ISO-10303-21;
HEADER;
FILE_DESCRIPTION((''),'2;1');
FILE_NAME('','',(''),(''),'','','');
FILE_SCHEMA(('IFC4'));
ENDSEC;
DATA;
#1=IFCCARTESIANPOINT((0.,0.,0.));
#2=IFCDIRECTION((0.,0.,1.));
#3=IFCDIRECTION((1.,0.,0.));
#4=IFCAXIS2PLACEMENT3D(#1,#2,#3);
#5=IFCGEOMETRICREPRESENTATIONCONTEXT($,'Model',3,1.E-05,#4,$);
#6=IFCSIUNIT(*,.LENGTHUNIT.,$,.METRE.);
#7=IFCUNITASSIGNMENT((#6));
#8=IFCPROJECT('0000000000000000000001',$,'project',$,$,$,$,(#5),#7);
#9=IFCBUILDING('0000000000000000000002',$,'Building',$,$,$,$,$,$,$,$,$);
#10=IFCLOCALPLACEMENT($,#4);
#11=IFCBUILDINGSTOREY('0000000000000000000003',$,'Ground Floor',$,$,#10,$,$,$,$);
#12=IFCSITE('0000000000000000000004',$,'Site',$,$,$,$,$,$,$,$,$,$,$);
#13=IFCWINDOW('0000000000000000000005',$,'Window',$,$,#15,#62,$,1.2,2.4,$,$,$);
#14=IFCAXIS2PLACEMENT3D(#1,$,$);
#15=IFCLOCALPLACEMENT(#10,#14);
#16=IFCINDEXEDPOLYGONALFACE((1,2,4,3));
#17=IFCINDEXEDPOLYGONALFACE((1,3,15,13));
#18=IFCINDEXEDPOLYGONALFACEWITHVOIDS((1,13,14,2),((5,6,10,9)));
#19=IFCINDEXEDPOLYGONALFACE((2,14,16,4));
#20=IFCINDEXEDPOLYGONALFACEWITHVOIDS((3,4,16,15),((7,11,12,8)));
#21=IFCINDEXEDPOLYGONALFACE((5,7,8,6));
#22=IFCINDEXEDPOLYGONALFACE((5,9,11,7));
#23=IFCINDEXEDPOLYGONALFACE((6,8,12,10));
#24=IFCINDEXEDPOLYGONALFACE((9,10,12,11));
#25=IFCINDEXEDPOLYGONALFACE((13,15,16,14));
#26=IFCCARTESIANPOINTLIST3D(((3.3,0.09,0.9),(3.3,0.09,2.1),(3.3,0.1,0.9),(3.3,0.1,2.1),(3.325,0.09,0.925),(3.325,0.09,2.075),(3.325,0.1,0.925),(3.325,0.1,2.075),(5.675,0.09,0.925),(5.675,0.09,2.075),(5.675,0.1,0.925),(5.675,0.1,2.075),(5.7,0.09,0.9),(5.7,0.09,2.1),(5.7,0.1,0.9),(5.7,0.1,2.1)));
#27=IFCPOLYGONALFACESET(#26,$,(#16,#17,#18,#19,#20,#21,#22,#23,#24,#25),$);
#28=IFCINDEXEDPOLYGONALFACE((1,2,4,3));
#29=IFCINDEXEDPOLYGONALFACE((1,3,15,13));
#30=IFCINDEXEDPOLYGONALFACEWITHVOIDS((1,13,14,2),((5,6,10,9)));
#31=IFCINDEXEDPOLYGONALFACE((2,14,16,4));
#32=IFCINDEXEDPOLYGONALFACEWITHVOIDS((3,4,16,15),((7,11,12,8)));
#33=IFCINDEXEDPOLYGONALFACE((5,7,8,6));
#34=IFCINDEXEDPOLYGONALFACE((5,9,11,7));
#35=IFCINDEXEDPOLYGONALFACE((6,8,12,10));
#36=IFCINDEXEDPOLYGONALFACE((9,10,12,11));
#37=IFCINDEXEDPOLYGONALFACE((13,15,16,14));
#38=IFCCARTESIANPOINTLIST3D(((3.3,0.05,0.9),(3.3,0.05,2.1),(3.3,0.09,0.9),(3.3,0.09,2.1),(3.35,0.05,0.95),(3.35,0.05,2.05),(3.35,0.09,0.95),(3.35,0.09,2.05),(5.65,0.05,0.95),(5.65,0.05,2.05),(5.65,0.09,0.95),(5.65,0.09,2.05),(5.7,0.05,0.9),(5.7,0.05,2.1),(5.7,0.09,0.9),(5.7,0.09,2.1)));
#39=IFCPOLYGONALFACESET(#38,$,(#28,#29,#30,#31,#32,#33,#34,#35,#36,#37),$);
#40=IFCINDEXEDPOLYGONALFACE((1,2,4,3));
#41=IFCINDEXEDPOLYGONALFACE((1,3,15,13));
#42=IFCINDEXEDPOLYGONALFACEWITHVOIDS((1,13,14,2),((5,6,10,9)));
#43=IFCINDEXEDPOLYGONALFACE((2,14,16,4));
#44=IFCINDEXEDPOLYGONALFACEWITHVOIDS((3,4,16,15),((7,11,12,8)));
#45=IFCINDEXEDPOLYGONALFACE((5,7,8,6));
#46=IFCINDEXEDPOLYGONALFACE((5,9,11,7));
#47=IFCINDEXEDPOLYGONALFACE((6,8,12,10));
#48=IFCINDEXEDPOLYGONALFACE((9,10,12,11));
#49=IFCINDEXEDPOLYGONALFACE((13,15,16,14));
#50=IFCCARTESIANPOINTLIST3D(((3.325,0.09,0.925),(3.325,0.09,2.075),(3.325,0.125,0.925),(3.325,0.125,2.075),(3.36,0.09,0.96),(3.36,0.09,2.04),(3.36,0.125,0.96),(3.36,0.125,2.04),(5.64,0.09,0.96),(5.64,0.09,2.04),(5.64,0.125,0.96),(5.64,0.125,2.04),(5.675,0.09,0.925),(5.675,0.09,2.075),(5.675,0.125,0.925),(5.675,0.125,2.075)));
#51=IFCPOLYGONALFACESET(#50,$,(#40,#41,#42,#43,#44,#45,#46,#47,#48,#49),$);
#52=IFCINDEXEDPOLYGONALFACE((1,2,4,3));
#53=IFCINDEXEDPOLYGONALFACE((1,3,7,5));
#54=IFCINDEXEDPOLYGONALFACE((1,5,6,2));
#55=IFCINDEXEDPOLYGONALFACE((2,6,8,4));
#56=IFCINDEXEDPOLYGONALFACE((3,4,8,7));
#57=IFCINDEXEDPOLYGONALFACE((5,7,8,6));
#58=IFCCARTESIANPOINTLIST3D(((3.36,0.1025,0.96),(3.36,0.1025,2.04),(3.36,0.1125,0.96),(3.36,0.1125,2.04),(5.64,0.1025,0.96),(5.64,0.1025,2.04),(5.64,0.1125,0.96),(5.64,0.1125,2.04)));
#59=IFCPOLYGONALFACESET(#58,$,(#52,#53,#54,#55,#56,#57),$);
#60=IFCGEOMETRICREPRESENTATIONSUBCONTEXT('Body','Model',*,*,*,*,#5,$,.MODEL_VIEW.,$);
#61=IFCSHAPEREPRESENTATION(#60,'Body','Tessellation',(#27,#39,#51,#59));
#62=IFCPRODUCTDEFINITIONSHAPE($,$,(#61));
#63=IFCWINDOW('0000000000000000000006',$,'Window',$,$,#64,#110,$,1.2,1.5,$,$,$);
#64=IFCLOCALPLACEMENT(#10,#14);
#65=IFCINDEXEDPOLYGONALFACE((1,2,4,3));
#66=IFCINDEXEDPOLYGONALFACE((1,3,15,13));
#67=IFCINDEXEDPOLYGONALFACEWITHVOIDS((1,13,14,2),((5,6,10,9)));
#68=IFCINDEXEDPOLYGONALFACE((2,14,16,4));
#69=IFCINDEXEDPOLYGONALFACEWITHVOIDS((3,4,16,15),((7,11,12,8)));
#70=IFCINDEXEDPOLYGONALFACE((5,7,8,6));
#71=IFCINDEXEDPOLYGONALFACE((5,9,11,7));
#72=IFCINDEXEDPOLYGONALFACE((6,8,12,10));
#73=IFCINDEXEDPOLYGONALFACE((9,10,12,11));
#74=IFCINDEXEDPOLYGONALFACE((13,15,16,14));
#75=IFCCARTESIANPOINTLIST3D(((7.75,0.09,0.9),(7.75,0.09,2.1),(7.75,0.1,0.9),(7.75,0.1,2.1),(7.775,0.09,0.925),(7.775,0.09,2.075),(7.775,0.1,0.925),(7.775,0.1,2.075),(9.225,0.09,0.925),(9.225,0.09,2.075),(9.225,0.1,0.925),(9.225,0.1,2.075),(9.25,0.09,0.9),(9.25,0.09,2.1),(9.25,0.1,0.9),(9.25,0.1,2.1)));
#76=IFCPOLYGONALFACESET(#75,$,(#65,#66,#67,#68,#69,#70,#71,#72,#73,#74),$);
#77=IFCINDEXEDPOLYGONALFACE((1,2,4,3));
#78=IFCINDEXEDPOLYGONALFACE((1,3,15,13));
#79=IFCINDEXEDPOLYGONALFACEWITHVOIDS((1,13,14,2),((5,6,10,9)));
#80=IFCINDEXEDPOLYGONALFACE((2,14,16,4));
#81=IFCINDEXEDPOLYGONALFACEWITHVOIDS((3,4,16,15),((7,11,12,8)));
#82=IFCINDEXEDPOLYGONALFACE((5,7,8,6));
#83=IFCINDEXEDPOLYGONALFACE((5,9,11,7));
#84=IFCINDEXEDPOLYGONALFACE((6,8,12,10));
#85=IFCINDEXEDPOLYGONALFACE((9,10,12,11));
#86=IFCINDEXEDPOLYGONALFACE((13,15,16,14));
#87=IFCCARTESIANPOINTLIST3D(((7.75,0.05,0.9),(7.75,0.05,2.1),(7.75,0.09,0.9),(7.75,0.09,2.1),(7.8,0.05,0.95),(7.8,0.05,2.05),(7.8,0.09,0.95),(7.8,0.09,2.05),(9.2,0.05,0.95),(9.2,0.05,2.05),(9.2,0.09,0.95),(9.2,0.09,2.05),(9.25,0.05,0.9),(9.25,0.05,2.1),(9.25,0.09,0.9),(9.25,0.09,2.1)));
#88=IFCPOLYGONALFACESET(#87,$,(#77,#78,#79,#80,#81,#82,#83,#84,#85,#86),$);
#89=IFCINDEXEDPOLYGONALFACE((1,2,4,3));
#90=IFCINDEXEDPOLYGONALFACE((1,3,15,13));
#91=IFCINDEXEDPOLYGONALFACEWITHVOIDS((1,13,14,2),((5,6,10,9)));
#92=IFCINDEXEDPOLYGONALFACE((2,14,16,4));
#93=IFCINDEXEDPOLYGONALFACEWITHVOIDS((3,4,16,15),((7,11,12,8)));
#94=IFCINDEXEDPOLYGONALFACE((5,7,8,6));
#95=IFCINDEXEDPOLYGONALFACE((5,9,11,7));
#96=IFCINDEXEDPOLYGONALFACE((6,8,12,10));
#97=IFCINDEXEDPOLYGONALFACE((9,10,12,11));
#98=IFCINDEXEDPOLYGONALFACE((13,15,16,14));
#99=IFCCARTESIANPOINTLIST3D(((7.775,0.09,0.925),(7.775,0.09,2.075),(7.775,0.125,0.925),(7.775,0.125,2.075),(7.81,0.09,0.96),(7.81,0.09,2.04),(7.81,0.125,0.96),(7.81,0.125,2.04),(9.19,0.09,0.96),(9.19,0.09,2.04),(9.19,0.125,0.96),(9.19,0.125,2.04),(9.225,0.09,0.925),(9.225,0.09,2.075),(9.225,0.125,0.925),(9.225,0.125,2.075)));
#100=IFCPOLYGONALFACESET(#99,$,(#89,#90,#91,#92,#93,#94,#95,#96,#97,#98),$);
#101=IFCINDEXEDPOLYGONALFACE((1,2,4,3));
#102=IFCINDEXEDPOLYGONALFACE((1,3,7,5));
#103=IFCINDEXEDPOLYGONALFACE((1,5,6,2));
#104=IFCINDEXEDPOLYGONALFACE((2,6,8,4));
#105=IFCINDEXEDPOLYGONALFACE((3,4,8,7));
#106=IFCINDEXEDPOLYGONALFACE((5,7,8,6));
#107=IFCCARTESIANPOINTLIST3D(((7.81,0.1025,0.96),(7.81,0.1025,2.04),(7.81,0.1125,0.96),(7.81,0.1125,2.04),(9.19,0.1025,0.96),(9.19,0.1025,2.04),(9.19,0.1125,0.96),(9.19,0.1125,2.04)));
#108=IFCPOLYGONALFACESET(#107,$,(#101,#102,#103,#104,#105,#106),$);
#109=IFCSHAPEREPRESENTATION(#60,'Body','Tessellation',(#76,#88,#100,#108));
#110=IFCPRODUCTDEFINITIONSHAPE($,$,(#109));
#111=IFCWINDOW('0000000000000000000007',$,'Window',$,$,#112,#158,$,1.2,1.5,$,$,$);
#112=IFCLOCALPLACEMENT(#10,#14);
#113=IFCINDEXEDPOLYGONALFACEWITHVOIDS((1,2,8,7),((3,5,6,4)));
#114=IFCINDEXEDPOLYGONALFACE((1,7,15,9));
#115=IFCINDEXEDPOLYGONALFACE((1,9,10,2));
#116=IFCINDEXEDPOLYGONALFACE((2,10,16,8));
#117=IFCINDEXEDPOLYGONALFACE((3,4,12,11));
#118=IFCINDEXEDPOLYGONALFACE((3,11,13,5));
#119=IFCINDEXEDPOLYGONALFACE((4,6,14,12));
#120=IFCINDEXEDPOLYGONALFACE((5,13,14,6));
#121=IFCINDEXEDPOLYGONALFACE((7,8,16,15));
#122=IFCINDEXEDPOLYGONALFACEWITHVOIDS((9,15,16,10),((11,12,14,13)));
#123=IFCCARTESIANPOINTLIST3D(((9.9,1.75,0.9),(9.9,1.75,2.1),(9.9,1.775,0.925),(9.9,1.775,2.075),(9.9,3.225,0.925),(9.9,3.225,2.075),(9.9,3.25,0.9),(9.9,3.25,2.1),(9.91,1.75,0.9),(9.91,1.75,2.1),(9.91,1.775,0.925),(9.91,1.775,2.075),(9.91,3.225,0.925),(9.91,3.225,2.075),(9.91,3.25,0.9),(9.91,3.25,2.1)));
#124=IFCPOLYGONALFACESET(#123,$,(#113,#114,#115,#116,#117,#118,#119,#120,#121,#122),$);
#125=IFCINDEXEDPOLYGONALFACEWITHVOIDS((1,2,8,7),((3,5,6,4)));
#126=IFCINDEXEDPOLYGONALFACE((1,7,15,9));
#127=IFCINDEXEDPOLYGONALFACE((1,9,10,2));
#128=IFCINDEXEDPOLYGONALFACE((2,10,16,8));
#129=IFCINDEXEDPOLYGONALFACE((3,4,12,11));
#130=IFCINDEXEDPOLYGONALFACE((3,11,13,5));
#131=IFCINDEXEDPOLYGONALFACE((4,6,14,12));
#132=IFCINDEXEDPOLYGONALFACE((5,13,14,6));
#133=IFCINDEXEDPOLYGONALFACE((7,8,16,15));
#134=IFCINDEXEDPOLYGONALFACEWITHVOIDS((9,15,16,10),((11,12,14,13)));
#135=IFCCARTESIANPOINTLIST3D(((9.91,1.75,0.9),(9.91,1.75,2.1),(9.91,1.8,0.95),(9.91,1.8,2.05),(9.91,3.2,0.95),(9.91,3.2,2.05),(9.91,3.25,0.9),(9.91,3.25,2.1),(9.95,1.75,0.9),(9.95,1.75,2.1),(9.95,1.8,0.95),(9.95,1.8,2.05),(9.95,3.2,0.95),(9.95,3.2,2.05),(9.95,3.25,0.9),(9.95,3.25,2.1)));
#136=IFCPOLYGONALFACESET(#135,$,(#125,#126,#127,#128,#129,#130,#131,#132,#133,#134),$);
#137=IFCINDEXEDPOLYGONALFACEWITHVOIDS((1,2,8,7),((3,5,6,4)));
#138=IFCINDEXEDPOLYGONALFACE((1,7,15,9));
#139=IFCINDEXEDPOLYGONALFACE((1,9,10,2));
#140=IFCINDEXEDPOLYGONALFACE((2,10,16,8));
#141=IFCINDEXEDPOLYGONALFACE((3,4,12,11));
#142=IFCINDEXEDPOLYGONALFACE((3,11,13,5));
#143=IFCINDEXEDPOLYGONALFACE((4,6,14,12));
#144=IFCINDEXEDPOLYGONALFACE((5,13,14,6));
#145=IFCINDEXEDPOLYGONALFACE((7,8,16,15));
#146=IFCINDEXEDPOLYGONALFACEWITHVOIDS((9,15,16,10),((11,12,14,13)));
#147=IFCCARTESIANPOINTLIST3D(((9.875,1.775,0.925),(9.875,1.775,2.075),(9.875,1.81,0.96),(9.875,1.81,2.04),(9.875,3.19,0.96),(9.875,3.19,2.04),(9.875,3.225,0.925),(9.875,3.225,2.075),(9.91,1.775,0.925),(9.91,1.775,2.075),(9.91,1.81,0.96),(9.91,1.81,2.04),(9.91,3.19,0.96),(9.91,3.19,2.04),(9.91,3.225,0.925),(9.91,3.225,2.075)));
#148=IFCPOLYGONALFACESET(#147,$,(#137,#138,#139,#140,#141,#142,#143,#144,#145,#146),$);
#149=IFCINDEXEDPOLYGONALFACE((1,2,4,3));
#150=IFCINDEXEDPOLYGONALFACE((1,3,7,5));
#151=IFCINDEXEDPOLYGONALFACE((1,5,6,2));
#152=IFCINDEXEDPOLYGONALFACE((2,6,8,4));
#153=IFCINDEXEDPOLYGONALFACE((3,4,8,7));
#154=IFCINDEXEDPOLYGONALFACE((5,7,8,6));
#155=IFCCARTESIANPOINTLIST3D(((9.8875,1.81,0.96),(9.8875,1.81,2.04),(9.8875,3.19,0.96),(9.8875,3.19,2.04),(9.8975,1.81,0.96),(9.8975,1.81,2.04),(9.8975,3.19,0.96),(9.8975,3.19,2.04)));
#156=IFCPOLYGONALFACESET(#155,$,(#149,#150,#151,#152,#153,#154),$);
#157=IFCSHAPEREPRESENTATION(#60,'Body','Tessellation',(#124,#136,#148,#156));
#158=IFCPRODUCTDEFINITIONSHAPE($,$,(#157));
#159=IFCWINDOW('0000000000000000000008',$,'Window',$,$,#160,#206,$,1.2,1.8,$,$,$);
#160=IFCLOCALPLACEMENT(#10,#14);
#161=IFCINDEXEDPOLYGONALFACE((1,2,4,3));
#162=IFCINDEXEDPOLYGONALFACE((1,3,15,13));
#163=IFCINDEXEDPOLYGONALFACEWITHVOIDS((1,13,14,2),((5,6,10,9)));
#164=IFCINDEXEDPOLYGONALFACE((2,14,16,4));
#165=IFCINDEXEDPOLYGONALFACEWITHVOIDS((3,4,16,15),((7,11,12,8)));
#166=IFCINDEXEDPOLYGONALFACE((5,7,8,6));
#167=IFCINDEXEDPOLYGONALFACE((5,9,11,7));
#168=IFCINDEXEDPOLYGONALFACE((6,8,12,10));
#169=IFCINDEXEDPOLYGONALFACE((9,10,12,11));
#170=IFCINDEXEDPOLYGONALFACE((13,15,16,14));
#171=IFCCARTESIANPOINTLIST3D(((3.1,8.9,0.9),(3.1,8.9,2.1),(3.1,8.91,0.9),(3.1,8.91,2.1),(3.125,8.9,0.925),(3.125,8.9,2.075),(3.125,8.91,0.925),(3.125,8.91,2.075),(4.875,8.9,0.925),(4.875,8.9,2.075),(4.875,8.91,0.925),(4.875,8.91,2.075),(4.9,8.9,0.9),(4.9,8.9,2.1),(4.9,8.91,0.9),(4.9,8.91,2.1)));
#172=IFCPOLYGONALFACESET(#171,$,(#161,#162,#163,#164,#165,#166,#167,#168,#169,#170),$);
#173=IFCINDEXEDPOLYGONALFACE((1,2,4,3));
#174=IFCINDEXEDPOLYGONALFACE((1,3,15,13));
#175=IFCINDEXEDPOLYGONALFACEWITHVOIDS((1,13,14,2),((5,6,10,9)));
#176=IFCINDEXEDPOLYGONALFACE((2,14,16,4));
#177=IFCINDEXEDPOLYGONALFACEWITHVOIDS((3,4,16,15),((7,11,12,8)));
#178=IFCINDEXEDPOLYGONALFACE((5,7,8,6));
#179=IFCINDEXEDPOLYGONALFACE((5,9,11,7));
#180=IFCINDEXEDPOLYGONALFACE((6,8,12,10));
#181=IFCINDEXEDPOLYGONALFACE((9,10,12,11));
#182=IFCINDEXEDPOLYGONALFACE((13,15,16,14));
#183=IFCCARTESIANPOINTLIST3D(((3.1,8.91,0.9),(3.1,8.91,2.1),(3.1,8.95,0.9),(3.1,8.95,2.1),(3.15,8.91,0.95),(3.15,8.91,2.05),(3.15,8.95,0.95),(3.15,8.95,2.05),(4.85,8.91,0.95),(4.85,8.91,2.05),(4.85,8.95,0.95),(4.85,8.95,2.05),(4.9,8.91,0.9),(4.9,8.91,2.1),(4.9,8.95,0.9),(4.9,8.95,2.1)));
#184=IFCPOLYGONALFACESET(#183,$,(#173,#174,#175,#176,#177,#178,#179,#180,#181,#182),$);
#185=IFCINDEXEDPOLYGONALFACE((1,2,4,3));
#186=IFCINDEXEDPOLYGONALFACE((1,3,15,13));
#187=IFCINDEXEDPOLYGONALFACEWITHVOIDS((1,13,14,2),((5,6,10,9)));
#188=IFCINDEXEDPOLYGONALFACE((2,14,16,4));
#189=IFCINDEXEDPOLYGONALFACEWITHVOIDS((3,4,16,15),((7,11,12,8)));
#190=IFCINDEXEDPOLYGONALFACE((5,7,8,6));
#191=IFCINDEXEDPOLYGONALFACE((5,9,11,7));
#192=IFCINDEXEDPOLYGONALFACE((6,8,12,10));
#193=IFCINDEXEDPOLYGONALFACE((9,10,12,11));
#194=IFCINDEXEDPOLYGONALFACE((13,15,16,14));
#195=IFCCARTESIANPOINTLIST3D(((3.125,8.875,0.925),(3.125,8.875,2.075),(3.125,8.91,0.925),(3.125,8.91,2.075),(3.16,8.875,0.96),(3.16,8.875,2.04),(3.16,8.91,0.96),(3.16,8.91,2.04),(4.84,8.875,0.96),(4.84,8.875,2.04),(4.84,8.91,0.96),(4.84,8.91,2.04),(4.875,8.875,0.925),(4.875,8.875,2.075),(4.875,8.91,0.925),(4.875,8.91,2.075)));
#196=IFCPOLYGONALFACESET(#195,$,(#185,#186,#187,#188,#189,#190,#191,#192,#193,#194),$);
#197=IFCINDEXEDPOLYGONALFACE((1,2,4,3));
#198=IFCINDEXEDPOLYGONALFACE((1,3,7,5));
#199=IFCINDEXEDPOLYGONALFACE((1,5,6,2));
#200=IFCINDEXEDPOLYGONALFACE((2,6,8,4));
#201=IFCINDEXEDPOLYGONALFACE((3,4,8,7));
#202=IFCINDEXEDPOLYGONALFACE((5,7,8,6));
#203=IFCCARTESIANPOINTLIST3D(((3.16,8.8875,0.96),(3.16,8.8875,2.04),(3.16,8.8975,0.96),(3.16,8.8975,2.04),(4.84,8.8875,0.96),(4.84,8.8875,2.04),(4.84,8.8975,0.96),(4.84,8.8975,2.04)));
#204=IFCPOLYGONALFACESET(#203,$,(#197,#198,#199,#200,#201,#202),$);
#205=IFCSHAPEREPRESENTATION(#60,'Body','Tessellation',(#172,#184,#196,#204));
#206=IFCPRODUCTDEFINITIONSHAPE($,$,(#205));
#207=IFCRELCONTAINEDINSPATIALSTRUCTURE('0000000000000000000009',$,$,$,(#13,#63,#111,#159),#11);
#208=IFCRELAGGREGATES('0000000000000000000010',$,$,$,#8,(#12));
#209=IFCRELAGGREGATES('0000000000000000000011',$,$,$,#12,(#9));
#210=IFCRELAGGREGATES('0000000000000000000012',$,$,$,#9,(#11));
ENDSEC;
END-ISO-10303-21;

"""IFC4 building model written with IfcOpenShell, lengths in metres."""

from ifc_helpers import new_model, si_unit, frame, origin_with_axes, place, context, subcontext, project, spatial, line, indexed_curve, outline, extrude, element, save


model = new_model("IFC4")

# Units and contexts
model_context = context("Model", 3, precision=1e-05, world=origin_with_axes())
body_context = subcontext(model_context, "Body", "Model", "MODEL_VIEW")
ifc_project = project(units=[si_unit("LENGTHUNIT", "METRE")], contexts=[model_context])

# Site, building, storey
site = spatial("IfcSite", under=ifc_project, Name="Site")
building = spatial("IfcBuilding", under=site, Name="Building")
storey_placement = place(None, origin_with_axes())
storey = spatial("IfcBuildingStorey", under=building, at=storey_placement, Name="Ground Floor")

# Windows
window_1_placement = place(storey_placement, frame((3.3, 0.0, 0.9), z_axis=(0.0, 0.0, 1.0), x_axis=(1.0, 0.0, 0.0)))
element("IfcWindow", 1, at=window_1_placement, inside=storey, Name="Window", OverallHeight=1.2, OverallWidth=2.4, context=body_context, shape_type="SweptSolid", body=[
    extrude(outline(indexed_curve([(0.0, 0.0), (2.4, 0.0), (2.4, 1.2), (0.0, 1.2)], segments=[line(1, 2, 3, 4, 1)]), holes=[indexed_curve([(0.025, 0.025), (2.375, 0.025), (2.375, 1.175), (0.025, 1.175)], segments=[line(1, 2, 3, 4, 1)])]), frame((0.0, 0.09, 0.0), z_axis=(0.0, -1.0, 0.0), x_axis=(1.0, 0.0, 0.0)), (0.0, 0.0, -1.0), 0.01),
    extrude(outline(indexed_curve([(0.0, 0.0), (2.4, 0.0), (2.4, 1.2), (0.0, 1.2)], segments=[line(1, 2, 3, 4, 1)]), holes=[indexed_curve([(0.05, 0.05), (2.35, 0.05), (2.35, 1.15), (0.05, 1.15)], segments=[line(1, 2, 3, 4, 1)])]), frame((0.0, 0.05, 0.0), z_axis=(0.0, -1.0, 0.0), x_axis=(1.0, 0.0, 0.0)), (0.0, 0.0, -1.0), 0.04),
    extrude(outline(indexed_curve([(0.0, 0.0), (2.35, 0.0), (2.35, 1.15), (0.0, 1.15)], segments=[line(1, 2, 3, 4, 1)]), holes=[indexed_curve([(0.035, 0.035), (2.315, 0.035), (2.315, 1.115), (0.035, 1.115)], segments=[line(1, 2, 3, 4, 1)])]), frame((0.025, 0.09, 0.025), z_axis=(0.0, -1.0, 0.0), x_axis=(1.0, 0.0, 0.0)), (0.0, 0.0, -1.0), 0.035),
    extrude(outline(indexed_curve([(0.035, 0.035), (2.315, 0.035), (2.315, 1.115), (0.035, 1.115)], segments=[line(1, 2, 3, 4, 1)])), frame((0.025, 0.1025, 0.025), z_axis=(0.0, -1.0, 0.0), x_axis=(1.0, 0.0, 0.0)), (0.0, 0.0, -1.0), 0.01),
])
for number, where, z_axis, x_axis, name in (
    (2, (7.75, 0.0, 0.9), (0.0, 0.0, 1.0), (1.0, 0.0, 0.0), "Window"),
    (3, (10.0, 1.75, 0.9), (0.0, 0.0, 1.0), (0.0, 1.0, 0.0), "Window"),
):
    element("IfcWindow", number, at=place(storey_placement, frame(where, z_axis=z_axis, x_axis=x_axis)), inside=storey, Name=name, OverallHeight=1.2, OverallWidth=1.5, context=body_context, shape_type="SweptSolid", body=[
        extrude(outline(indexed_curve([(0.0, 0.0), (1.5, 0.0), (1.5, 1.2), (0.0, 1.2)], segments=[line(1, 2, 3, 4, 1)]), holes=[indexed_curve([(0.025, 0.025), (1.475, 0.025), (1.475, 1.175), (0.025, 1.175)], segments=[line(1, 2, 3, 4, 1)])]), frame((0.0, 0.09, 0.0), z_axis=(0.0, -1.0, 0.0), x_axis=(1.0, 0.0, 0.0)), (0.0, 0.0, -1.0), 0.01),
        extrude(outline(indexed_curve([(0.0, 0.0), (1.5, 0.0), (1.5, 1.2), (0.0, 1.2)], segments=[line(1, 2, 3, 4, 1)]), holes=[indexed_curve([(0.05, 0.05), (1.45, 0.05), (1.45, 1.15), (0.05, 1.15)], segments=[line(1, 2, 3, 4, 1)])]), frame((0.0, 0.05, 0.0), z_axis=(0.0, -1.0, 0.0), x_axis=(1.0, 0.0, 0.0)), (0.0, 0.0, -1.0), 0.04),
        extrude(outline(indexed_curve([(0.0, 0.0), (1.45, 0.0), (1.45, 1.15), (0.0, 1.15)], segments=[line(1, 2, 3, 4, 1)]), holes=[indexed_curve([(0.035, 0.035), (1.415, 0.035), (1.415, 1.115), (0.035, 1.115)], segments=[line(1, 2, 3, 4, 1)])]), frame((0.025, 0.09, 0.025), z_axis=(0.0, -1.0, 0.0), x_axis=(1.0, 0.0, 0.0)), (0.0, 0.0, -1.0), 0.035),
        extrude(outline(indexed_curve([(0.035, 0.035), (1.415, 0.035), (1.415, 1.115), (0.035, 1.115)], segments=[line(1, 2, 3, 4, 1)])), frame((0.025, 0.1025, 0.025), z_axis=(0.0, -1.0, 0.0), x_axis=(1.0, 0.0, 0.0)), (0.0, 0.0, -1.0), 0.01),
    ])
for number, where, z_axis, x_axis, name in (
    (4, (4.9, 9.0, 0.9), (0.0, 0.0, 1.0), (-1.0, 0.0, 0.0), "Window"),
):
    element("IfcWindow", number, at=place(storey_placement, frame(where, z_axis=z_axis, x_axis=x_axis)), inside=storey, Name=name, OverallHeight=1.2, OverallWidth=1.8, context=body_context, shape_type="SweptSolid", body=[
        extrude(outline(indexed_curve([(0.0, 0.0), (1.8, 0.0), (1.8, 1.2), (0.0, 1.2)], segments=[line(1, 2, 3, 4, 1)]), holes=[indexed_curve([(0.025, 0.025), (1.775, 0.025), (1.775, 1.175), (0.025, 1.175)], segments=[line(1, 2, 3, 4, 1)])]), frame((0.0, 0.09, 0.0), z_axis=(0.0, -1.0, 0.0), x_axis=(1.0, 0.0, 0.0)), (0.0, 0.0, -1.0), 0.01),
        extrude(outline(indexed_curve([(0.0, 0.0), (1.8, 0.0), (1.8, 1.2), (0.0, 1.2)], segments=[line(1, 2, 3, 4, 1)]), holes=[indexed_curve([(0.05, 0.05), (1.75, 0.05), (1.75, 1.15), (0.05, 1.15)], segments=[line(1, 2, 3, 4, 1)])]), frame((0.0, 0.05, 0.0), z_axis=(0.0, -1.0, 0.0), x_axis=(1.0, 0.0, 0.0)), (0.0, 0.0, -1.0), 0.04),
        extrude(outline(indexed_curve([(0.0, 0.0), (1.75, 0.0), (1.75, 1.15), (0.0, 1.15)], segments=[line(1, 2, 3, 4, 1)]), holes=[indexed_curve([(0.035, 0.035), (1.715, 0.035), (1.715, 1.115), (0.035, 1.115)], segments=[line(1, 2, 3, 4, 1)])]), frame((0.025, 0.09, 0.025), z_axis=(0.0, -1.0, 0.0), x_axis=(1.0, 0.0, 0.0)), (0.0, 0.0, -1.0), 0.035),
        extrude(outline(indexed_curve([(0.035, 0.035), (1.715, 0.035), (1.715, 1.115), (0.035, 1.115)], segments=[line(1, 2, 3, 4, 1)])), frame((0.025, 0.1025, 0.025), z_axis=(0.0, -1.0, 0.0), x_axis=(1.0, 0.0, 0.0)), (0.0, 0.0, -1.0), 0.01),
    ])

save(model, "model.ifc")
